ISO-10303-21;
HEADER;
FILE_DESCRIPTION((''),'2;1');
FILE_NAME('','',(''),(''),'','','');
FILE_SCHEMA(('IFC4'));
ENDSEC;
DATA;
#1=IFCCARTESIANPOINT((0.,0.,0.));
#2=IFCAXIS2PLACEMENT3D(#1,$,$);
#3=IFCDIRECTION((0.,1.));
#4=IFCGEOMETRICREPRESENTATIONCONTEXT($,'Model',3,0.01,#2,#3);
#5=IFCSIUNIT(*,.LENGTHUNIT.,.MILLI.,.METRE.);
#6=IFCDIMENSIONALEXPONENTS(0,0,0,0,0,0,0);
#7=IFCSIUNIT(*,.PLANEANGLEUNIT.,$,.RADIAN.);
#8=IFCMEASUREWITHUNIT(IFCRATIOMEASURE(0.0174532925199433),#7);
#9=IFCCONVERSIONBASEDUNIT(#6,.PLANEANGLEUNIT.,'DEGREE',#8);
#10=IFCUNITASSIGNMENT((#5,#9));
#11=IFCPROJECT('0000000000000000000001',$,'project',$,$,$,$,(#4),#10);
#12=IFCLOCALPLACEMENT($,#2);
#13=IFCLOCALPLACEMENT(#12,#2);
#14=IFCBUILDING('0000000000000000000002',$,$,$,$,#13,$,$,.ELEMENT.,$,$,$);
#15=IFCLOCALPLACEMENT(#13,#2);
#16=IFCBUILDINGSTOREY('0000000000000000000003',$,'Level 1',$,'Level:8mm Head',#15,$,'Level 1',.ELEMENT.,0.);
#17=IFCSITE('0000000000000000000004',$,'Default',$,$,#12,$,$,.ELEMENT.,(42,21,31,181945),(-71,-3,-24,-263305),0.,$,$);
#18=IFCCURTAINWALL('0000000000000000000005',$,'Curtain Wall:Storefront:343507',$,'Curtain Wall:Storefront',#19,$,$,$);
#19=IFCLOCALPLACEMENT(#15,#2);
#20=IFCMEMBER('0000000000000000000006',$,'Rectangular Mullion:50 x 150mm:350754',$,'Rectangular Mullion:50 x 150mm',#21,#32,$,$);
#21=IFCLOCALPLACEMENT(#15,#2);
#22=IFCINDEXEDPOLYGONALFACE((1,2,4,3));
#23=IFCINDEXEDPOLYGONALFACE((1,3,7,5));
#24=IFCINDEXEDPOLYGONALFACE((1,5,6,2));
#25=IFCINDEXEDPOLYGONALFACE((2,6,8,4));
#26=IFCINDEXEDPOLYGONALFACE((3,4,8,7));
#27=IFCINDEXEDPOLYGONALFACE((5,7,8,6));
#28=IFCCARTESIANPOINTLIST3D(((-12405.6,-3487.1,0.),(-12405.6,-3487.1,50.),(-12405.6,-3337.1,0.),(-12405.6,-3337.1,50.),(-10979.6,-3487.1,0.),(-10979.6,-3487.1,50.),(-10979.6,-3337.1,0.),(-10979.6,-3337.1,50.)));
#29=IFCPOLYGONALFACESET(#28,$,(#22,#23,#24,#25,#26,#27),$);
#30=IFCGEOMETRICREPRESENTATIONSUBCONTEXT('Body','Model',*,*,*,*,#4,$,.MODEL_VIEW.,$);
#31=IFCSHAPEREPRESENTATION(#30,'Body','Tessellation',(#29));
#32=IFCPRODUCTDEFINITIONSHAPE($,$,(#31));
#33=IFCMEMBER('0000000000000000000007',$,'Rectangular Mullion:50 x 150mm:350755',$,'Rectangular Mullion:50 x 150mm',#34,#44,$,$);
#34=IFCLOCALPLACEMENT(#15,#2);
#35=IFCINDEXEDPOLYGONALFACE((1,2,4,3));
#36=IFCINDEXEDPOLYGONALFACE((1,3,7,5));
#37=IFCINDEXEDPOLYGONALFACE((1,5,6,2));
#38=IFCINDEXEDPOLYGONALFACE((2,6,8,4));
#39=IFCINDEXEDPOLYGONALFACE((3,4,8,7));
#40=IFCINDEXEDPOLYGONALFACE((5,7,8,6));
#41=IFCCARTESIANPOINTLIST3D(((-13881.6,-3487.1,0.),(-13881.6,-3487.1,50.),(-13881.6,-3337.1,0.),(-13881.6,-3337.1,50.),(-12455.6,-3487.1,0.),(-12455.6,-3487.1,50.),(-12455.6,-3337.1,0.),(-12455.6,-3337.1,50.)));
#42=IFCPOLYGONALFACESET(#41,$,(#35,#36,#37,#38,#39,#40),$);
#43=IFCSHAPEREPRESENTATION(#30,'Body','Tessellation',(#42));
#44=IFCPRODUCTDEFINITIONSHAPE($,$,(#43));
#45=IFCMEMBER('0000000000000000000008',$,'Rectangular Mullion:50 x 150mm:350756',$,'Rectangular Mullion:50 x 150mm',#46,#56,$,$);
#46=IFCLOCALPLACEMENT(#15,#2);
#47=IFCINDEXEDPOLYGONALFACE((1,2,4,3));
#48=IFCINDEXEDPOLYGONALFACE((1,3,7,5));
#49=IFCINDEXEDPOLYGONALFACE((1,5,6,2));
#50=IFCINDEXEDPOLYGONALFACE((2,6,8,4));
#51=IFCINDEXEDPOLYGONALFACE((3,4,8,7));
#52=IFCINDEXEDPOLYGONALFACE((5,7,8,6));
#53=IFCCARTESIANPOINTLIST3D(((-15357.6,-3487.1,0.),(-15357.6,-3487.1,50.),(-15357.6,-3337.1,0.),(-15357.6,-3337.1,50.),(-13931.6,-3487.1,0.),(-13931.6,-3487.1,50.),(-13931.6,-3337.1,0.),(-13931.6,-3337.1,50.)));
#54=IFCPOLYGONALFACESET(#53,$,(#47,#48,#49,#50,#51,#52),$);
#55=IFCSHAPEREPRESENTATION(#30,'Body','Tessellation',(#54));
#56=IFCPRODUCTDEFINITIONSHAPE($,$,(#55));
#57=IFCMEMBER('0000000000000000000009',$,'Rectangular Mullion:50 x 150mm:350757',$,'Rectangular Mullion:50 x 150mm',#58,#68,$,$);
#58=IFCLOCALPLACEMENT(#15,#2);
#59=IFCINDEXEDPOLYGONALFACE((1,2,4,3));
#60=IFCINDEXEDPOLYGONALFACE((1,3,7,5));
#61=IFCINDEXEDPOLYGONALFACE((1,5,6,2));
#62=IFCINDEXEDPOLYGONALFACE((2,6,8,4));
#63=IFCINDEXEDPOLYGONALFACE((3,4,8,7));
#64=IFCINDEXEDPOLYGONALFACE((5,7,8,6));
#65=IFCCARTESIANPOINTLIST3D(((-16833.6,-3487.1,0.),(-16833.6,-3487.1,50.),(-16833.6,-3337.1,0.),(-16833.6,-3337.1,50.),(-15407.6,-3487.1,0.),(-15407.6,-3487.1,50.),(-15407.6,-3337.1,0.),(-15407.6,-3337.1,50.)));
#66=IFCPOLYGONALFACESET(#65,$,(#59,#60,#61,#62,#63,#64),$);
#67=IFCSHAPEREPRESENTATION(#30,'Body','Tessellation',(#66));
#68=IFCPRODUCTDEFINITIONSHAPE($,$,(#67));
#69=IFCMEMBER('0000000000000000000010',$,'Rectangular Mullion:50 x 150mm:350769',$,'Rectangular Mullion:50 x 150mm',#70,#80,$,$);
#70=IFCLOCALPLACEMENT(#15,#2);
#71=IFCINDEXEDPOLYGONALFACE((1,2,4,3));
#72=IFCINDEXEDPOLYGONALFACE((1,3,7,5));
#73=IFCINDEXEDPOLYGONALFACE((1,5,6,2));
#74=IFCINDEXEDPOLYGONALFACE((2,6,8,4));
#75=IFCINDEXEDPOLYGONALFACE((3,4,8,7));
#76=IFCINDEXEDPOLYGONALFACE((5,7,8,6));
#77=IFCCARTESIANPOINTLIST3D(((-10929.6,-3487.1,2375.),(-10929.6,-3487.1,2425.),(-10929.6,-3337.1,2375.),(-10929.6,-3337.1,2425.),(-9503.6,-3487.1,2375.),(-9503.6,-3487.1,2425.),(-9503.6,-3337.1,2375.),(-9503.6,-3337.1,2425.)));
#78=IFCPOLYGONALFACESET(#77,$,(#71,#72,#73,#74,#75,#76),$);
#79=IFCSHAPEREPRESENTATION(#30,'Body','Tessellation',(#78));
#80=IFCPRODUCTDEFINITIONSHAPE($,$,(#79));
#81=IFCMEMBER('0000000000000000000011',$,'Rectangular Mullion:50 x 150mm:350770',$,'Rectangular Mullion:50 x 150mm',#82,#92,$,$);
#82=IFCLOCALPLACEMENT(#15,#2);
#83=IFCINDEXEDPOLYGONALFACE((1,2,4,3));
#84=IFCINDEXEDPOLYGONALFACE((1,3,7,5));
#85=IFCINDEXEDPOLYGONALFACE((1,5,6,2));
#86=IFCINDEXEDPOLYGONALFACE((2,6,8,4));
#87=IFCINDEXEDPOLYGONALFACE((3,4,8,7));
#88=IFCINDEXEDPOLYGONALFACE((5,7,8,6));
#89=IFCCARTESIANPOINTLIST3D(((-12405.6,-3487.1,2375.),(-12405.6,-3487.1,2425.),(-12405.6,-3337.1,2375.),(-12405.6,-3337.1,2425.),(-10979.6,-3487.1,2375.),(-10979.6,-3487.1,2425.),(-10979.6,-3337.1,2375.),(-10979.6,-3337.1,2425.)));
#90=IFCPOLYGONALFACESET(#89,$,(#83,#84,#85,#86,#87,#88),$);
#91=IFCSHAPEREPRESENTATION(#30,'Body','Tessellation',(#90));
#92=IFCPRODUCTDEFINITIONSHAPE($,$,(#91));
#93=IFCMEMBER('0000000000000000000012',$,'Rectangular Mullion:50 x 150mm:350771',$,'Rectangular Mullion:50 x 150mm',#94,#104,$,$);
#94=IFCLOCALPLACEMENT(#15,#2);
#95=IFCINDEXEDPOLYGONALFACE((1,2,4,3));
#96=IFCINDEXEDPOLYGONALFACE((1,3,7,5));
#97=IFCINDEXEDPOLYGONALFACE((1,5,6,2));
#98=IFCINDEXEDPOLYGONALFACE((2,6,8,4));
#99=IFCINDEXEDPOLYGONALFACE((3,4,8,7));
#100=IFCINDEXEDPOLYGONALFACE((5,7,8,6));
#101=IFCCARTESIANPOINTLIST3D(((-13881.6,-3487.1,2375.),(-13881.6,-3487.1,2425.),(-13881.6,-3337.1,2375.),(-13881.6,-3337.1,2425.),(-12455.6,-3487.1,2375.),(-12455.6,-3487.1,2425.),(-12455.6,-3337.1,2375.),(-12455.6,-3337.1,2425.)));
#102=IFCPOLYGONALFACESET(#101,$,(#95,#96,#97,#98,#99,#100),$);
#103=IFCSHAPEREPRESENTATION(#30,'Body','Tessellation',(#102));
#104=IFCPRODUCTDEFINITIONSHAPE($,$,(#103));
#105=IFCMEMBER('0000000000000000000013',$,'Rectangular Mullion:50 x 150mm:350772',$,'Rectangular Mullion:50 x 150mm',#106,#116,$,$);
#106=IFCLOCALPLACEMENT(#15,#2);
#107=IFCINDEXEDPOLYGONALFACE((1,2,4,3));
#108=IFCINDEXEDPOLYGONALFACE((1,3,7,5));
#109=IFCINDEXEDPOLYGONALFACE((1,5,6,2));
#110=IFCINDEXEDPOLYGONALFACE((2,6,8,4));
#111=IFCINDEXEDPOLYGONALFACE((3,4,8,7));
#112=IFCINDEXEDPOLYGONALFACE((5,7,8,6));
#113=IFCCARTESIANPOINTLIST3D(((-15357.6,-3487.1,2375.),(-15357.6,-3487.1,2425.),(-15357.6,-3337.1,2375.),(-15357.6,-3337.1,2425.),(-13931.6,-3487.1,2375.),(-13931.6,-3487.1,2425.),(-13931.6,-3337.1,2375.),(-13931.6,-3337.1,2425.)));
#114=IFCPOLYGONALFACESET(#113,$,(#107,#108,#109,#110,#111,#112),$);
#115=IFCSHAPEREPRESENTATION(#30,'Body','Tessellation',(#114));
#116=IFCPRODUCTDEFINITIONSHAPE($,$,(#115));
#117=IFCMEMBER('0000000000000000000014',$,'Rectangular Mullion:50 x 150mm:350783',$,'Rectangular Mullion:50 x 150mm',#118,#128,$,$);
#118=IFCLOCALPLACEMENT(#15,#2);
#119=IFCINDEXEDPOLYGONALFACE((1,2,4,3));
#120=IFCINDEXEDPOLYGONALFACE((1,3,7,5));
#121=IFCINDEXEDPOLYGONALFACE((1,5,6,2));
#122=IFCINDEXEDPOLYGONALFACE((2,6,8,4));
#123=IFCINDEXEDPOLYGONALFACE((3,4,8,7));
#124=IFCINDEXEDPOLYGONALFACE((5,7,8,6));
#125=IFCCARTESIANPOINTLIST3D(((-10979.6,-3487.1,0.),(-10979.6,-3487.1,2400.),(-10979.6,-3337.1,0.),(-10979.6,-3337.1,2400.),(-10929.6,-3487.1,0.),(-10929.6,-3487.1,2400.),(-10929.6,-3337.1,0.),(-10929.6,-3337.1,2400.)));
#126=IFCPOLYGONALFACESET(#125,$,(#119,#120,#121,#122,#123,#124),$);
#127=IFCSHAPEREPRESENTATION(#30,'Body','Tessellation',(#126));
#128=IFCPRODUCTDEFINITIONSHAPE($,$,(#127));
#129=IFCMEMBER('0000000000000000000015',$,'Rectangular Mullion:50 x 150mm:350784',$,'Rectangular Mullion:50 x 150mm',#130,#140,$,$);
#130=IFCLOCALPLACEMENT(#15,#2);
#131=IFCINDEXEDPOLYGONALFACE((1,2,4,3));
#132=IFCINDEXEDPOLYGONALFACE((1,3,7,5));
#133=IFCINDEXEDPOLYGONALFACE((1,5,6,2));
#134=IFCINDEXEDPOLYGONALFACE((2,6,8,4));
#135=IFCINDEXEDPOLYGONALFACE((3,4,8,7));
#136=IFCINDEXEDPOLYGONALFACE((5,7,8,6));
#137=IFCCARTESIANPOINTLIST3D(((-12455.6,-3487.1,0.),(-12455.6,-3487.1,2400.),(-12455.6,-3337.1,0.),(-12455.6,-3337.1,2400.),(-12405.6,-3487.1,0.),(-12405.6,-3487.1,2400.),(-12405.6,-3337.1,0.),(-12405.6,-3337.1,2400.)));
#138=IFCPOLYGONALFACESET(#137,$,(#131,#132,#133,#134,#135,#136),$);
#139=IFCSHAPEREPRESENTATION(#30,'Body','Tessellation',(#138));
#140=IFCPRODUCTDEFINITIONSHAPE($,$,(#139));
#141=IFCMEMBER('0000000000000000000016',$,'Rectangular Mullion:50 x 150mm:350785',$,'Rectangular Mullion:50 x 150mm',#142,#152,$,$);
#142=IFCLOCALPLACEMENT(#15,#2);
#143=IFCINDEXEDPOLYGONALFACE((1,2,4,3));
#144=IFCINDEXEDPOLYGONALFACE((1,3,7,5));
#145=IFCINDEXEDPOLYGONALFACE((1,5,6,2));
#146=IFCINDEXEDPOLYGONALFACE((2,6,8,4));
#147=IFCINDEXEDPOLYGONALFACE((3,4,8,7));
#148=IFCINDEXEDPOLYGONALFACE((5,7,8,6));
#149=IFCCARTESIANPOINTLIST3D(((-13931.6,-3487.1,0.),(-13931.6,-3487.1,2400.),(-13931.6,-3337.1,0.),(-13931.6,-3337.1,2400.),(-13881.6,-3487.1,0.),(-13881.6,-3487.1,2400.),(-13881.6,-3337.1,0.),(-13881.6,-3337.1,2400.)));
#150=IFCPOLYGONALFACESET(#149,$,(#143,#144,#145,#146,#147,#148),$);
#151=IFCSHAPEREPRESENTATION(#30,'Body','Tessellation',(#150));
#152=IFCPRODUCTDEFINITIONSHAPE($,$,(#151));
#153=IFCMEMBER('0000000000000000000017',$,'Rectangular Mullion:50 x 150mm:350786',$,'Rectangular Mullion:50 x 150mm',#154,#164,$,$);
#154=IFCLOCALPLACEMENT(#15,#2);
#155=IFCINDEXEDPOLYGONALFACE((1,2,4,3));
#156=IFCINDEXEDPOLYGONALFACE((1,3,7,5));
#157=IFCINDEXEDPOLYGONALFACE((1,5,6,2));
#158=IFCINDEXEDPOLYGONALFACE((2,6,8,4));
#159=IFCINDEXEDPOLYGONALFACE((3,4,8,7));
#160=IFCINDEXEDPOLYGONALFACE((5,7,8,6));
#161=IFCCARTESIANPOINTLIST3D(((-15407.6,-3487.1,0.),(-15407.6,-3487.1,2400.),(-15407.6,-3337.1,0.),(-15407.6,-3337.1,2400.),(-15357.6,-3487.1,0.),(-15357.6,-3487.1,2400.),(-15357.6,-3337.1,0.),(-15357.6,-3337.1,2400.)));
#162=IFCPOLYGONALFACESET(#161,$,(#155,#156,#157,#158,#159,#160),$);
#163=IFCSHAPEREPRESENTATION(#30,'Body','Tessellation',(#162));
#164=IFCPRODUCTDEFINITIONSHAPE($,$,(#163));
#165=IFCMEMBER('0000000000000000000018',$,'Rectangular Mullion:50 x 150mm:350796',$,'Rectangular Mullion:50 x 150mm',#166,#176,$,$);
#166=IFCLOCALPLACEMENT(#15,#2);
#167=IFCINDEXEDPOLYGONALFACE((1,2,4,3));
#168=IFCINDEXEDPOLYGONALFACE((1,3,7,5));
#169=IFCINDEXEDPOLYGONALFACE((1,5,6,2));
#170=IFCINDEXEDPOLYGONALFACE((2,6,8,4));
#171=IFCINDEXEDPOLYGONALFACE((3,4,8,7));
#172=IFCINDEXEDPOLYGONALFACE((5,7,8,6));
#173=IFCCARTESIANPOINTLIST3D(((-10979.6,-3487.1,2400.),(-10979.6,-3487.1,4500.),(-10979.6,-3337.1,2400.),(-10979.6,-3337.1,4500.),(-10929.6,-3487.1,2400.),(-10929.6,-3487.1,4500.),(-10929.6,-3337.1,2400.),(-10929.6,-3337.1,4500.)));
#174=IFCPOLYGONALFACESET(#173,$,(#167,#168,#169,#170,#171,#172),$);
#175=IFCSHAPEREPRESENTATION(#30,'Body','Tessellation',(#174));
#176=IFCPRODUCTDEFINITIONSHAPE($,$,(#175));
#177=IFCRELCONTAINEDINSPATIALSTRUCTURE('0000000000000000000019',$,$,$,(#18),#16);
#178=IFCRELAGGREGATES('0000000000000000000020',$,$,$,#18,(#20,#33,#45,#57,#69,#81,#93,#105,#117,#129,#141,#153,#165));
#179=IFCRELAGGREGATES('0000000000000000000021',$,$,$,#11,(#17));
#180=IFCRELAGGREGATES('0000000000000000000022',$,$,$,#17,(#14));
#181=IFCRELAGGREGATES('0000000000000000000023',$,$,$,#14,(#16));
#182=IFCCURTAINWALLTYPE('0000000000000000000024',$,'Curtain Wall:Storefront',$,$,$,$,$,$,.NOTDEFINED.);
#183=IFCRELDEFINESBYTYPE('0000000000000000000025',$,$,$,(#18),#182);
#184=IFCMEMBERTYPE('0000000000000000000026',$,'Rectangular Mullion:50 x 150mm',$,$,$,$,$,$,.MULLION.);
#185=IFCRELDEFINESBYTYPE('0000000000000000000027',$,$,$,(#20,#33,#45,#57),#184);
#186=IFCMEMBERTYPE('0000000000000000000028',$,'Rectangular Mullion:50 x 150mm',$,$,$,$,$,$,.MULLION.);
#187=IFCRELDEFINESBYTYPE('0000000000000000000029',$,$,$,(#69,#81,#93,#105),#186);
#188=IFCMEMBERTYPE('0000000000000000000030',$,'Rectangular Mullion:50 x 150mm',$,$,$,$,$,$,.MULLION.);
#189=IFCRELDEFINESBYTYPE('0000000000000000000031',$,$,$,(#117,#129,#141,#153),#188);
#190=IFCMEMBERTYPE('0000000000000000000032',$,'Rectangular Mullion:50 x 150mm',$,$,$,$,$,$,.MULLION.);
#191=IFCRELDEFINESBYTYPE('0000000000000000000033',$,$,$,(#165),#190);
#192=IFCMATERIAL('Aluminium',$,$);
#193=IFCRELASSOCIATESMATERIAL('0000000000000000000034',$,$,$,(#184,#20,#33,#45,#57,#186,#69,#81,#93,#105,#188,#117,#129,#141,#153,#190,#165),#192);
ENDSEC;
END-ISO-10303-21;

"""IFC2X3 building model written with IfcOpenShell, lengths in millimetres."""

from ifc_helpers import new_model, entity, si_unit, converted_unit, direction, frame, origin, origin_2d_with_axis, place, context, subcontext, project, spatial, rectangle, extrude, source, transform, mapped, material, type_object, type_shapes, element, aggregate, save


model = new_model("IFC2X3")

# Units and contexts
model_context = context("Model", 3, precision=0.01, world=origin(), true_north=direction((0.0, 1.0)))
body_context = subcontext(model_context, "Body", "Model", "MODEL_VIEW")
ifc_project = project(units=[si_unit("LENGTHUNIT", "METRE", prefix="MILLI"), converted_unit("PLANEANGLEUNIT", "DEGREE", entity("IfcRatioMeasure", 0.0174532925199433), si_unit("PLANEANGLEUNIT", "RADIAN"), dimensions=[0, 0, 0, 0, 0, 0, 0])], contexts=[model_context])

# Site, building, storey
site_placement = place(None, frame((0.0, 0.0, 0.0)))
site = spatial("IfcSite", under=ifc_project, at=site_placement, Name="Default", CompositionType="ELEMENT", RefLatitude=(42, 21, 31, 181945), RefLongitude=(-71, -3, -24, -263305), RefElevation=0.0)
building_placement = place(site_placement, origin())
building = spatial("IfcBuilding", under=site, at=building_placement, CompositionType="ELEMENT")
storey_placement = place(building_placement, origin())
storey = spatial("IfcBuildingStorey", under=building, at=storey_placement, Name="Level 1", ObjectType="Level:8mm Head", LongName="Level 1", CompositionType="ELEMENT", Elevation=0.0)

# Curtain wall, members
curtain_wall_type = type_object("IfcCurtainWallType", Name="Curtain Wall:Storefront", PredefinedType="NOTDEFINED")
curtain_wall_placement = place(storey_placement, origin())
curtain_wall = element("IfcCurtainWall", 1, at=curtain_wall_placement, inside=storey, type_object=curtain_wall_type, Name="Curtain Wall:Storefront:343507", ObjectType="Curtain Wall:Storefront")
ifc_material_1 = material(Name="Aluminium")
member_type_1 = type_object("IfcMemberType", Name="Rectangular Mullion:50 x 150mm", PredefinedType="MULLION", material=ifc_material_1)
shared_shape_1 = source(origin(), body_context, "Body", "SweptSolid", [
    extrude(rectangle(XDim=150.0, YDim=50.0, at=origin_2d_with_axis()), frame((-25.0, 0.0, -1426.0), z_axis=(0.0, 0.0, 1.0), x_axis=(0.0, -1.0, 0.0)), (0.0, 0.0, 1.0), 1426.0),
])
type_shapes(member_type_1, [shared_shape_1])
member_1_placement = place(storey_placement, frame((-10979.6, -3412.1, 0.0), z_axis=(1.0, 0.0, 0.0), x_axis=(0.0, 0.0, -1.0)))
member_1 = element("IfcMember", 2, at=member_1_placement, type_object=member_type_1, material=ifc_material_1, Name="Rectangular Mullion:50 x 150mm:350754", ObjectType="Rectangular Mullion:50 x 150mm", context=body_context, shape_type="MappedRepresentation", body=[
    mapped(shared_shape_1, transform((0.0, 0.0, 0.0), scale=1.0)),
])
member_2_placement = place(storey_placement, frame((-12455.6, -3412.1, 0.0), z_axis=(1.0, 0.0, 0.0), x_axis=(0.0, 0.0, -1.0)))
member_2 = element("IfcMember", 3, at=member_2_placement, type_object=member_type_1, material=ifc_material_1, Name="Rectangular Mullion:50 x 150mm:350755", ObjectType="Rectangular Mullion:50 x 150mm", context=body_context, shape_type="MappedRepresentation", body=[
    mapped(shared_shape_1, transform((0.0, 0.0, 0.0), scale=1.0)),
])
member_3_placement = place(storey_placement, frame((-13931.6, -3412.1, 0.0), z_axis=(1.0, 0.0, 0.0), x_axis=(0.0, 0.0, -1.0)))
member_3 = element("IfcMember", 4, at=member_3_placement, type_object=member_type_1, material=ifc_material_1, Name="Rectangular Mullion:50 x 150mm:350756", ObjectType="Rectangular Mullion:50 x 150mm", context=body_context, shape_type="MappedRepresentation", body=[
    mapped(shared_shape_1, transform((0.0, 0.0, 0.0), scale=1.0)),
])
member_4_placement = place(storey_placement, frame((-15407.6, -3412.1, 0.0), z_axis=(1.0, 0.0, 0.0), x_axis=(0.0, 0.0, -1.0)))
member_4 = element("IfcMember", 5, at=member_4_placement, type_object=member_type_1, material=ifc_material_1, Name="Rectangular Mullion:50 x 150mm:350757", ObjectType="Rectangular Mullion:50 x 150mm", context=body_context, shape_type="MappedRepresentation", body=[
    mapped(shared_shape_1, transform((0.0, 0.0, 0.0), scale=1.0)),
])
member_type_2 = type_object("IfcMemberType", Name="Rectangular Mullion:50 x 150mm", PredefinedType="MULLION", material=ifc_material_1)
shared_shape_2 = source(origin(), body_context, "Body", "SweptSolid", [
    extrude(rectangle(XDim=150.0, YDim=50.0, at=origin_2d_with_axis()), frame((0.0, 0.0, -1426.0), z_axis=(0.0, 0.0, 1.0), x_axis=(0.0, -1.0, 0.0)), (0.0, 0.0, 1.0), 1426.0),
])
type_shapes(member_type_2, [shared_shape_2])
member_5_placement = place(storey_placement, frame((-10929.6, -3412.1, 2400.0), z_axis=(-1.0, 0.0, 0.0), x_axis=(0.0, 0.0, 1.0)))
member_5 = element("IfcMember", 6, at=member_5_placement, type_object=member_type_2, material=ifc_material_1, Name="Rectangular Mullion:50 x 150mm:350769", ObjectType="Rectangular Mullion:50 x 150mm", context=body_context, shape_type="MappedRepresentation", body=[
    mapped(shared_shape_2, transform((0.0, 0.0, 0.0), scale=1.0)),
])
member_6_placement = place(storey_placement, frame((-12405.6, -3412.1, 2400.0), z_axis=(-1.0, 0.0, 0.0), x_axis=(0.0, 0.0, 1.0)))
member_6 = element("IfcMember", 7, at=member_6_placement, type_object=member_type_2, material=ifc_material_1, Name="Rectangular Mullion:50 x 150mm:350770", ObjectType="Rectangular Mullion:50 x 150mm", context=body_context, shape_type="MappedRepresentation", body=[
    mapped(shared_shape_2, transform((0.0, 0.0, 0.0), scale=1.0)),
])
member_7_placement = place(storey_placement, frame((-13881.6, -3412.1, 2400.0), z_axis=(-1.0, 0.0, 0.0), x_axis=(0.0, 0.0, 1.0)))
member_7 = element("IfcMember", 8, at=member_7_placement, type_object=member_type_2, material=ifc_material_1, Name="Rectangular Mullion:50 x 150mm:350771", ObjectType="Rectangular Mullion:50 x 150mm", context=body_context, shape_type="MappedRepresentation", body=[
    mapped(shared_shape_2, transform((0.0, 0.0, 0.0), scale=1.0)),
])
member_8_placement = place(storey_placement, frame((-15357.6, -3412.1, 2400.0), z_axis=(-1.0, 0.0, 0.0), x_axis=(0.0, 0.0, 1.0)))
member_8 = element("IfcMember", 9, at=member_8_placement, type_object=member_type_2, material=ifc_material_1, Name="Rectangular Mullion:50 x 150mm:350772", ObjectType="Rectangular Mullion:50 x 150mm", context=body_context, shape_type="MappedRepresentation", body=[
    mapped(shared_shape_2, transform((0.0, 0.0, 0.0), scale=1.0)),
])
member_type_3 = type_object("IfcMemberType", Name="Rectangular Mullion:50 x 150mm", PredefinedType="MULLION", material=ifc_material_1)
shared_shape_3 = source(origin(), body_context, "Body", "SweptSolid", [
    extrude(rectangle(XDim=150.0, YDim=50.0, at=origin_2d_with_axis()), frame((0.0, 0.0, -2400.0), z_axis=(0.0, 0.0, 1.0), x_axis=(0.0, -1.0, 0.0)), (0.0, 0.0, 1.0), 2400.0),
])
type_shapes(member_type_3, [shared_shape_3])
member_9_placement = place(storey_placement, frame((-10954.6, -3412.1, 0.0), z_axis=(0.0, 0.0, -1.0), x_axis=(-1.0, 0.0, 0.0)))
member_9 = element("IfcMember", 10, at=member_9_placement, type_object=member_type_3, material=ifc_material_1, Name="Rectangular Mullion:50 x 150mm:350783", ObjectType="Rectangular Mullion:50 x 150mm", context=body_context, shape_type="MappedRepresentation", body=[
    mapped(shared_shape_3, transform((0.0, 0.0, 0.0), scale=1.0)),
])
member_10_placement = place(storey_placement, frame((-12430.6, -3412.1, 0.0), z_axis=(0.0, 0.0, -1.0), x_axis=(-1.0, 0.0, 0.0)))
member_10 = element("IfcMember", 11, at=member_10_placement, type_object=member_type_3, material=ifc_material_1, Name="Rectangular Mullion:50 x 150mm:350784", ObjectType="Rectangular Mullion:50 x 150mm", context=body_context, shape_type="MappedRepresentation", body=[
    mapped(shared_shape_3, transform((0.0, 0.0, 0.0), scale=1.0)),
])
member_11_placement = place(storey_placement, frame((-13906.6, -3412.1, 0.0), z_axis=(0.0, 0.0, -1.0), x_axis=(-1.0, 0.0, 0.0)))
member_11 = element("IfcMember", 12, at=member_11_placement, type_object=member_type_3, material=ifc_material_1, Name="Rectangular Mullion:50 x 150mm:350785", ObjectType="Rectangular Mullion:50 x 150mm", context=body_context, shape_type="MappedRepresentation", body=[
    mapped(shared_shape_3, transform((0.0, 0.0, 0.0), scale=1.0)),
])
member_12_placement = place(storey_placement, frame((-15382.6, -3412.1, 0.0), z_axis=(0.0, 0.0, -1.0), x_axis=(-1.0, 0.0, 0.0)))
member_12 = element("IfcMember", 13, at=member_12_placement, type_object=member_type_3, material=ifc_material_1, Name="Rectangular Mullion:50 x 150mm:350786", ObjectType="Rectangular Mullion:50 x 150mm", context=body_context, shape_type="MappedRepresentation", body=[
    mapped(shared_shape_3, transform((0.0, 0.0, 0.0), scale=1.0)),
])
member_type_4 = type_object("IfcMemberType", Name="Rectangular Mullion:50 x 150mm", PredefinedType="MULLION", material=ifc_material_1)
shared_shape_4 = source(origin(), body_context, "Body", "SweptSolid", [
    extrude(rectangle(XDim=150.0, YDim=50.0, at=origin_2d_with_axis()), frame((0.0, 0.0, -2100.0), z_axis=(0.0, 0.0, 1.0), x_axis=(0.0, -1.0, 0.0)), (0.0, 0.0, 1.0), 2100.0),
])
type_shapes(member_type_4, [shared_shape_4])
member_13_placement = place(storey_placement, frame((-10954.6, -3412.1, 2400.0), z_axis=(0.0, 0.0, -1.0), x_axis=(-1.0, 0.0, 0.0)))
member_13 = element("IfcMember", 14, at=member_13_placement, type_object=member_type_4, material=ifc_material_1, Name="Rectangular Mullion:50 x 150mm:350796", ObjectType="Rectangular Mullion:50 x 150mm", context=body_context, shape_type="MappedRepresentation", body=[
    mapped(shared_shape_4, transform((0.0, 0.0, 0.0), scale=1.0)),
])
aggregate(curtain_wall, [member_1, member_2, member_3, member_4, member_5, member_6, member_7, member_8, member_9, member_10, member_11, member_12, member_13])

save(model, "model.ifc")
